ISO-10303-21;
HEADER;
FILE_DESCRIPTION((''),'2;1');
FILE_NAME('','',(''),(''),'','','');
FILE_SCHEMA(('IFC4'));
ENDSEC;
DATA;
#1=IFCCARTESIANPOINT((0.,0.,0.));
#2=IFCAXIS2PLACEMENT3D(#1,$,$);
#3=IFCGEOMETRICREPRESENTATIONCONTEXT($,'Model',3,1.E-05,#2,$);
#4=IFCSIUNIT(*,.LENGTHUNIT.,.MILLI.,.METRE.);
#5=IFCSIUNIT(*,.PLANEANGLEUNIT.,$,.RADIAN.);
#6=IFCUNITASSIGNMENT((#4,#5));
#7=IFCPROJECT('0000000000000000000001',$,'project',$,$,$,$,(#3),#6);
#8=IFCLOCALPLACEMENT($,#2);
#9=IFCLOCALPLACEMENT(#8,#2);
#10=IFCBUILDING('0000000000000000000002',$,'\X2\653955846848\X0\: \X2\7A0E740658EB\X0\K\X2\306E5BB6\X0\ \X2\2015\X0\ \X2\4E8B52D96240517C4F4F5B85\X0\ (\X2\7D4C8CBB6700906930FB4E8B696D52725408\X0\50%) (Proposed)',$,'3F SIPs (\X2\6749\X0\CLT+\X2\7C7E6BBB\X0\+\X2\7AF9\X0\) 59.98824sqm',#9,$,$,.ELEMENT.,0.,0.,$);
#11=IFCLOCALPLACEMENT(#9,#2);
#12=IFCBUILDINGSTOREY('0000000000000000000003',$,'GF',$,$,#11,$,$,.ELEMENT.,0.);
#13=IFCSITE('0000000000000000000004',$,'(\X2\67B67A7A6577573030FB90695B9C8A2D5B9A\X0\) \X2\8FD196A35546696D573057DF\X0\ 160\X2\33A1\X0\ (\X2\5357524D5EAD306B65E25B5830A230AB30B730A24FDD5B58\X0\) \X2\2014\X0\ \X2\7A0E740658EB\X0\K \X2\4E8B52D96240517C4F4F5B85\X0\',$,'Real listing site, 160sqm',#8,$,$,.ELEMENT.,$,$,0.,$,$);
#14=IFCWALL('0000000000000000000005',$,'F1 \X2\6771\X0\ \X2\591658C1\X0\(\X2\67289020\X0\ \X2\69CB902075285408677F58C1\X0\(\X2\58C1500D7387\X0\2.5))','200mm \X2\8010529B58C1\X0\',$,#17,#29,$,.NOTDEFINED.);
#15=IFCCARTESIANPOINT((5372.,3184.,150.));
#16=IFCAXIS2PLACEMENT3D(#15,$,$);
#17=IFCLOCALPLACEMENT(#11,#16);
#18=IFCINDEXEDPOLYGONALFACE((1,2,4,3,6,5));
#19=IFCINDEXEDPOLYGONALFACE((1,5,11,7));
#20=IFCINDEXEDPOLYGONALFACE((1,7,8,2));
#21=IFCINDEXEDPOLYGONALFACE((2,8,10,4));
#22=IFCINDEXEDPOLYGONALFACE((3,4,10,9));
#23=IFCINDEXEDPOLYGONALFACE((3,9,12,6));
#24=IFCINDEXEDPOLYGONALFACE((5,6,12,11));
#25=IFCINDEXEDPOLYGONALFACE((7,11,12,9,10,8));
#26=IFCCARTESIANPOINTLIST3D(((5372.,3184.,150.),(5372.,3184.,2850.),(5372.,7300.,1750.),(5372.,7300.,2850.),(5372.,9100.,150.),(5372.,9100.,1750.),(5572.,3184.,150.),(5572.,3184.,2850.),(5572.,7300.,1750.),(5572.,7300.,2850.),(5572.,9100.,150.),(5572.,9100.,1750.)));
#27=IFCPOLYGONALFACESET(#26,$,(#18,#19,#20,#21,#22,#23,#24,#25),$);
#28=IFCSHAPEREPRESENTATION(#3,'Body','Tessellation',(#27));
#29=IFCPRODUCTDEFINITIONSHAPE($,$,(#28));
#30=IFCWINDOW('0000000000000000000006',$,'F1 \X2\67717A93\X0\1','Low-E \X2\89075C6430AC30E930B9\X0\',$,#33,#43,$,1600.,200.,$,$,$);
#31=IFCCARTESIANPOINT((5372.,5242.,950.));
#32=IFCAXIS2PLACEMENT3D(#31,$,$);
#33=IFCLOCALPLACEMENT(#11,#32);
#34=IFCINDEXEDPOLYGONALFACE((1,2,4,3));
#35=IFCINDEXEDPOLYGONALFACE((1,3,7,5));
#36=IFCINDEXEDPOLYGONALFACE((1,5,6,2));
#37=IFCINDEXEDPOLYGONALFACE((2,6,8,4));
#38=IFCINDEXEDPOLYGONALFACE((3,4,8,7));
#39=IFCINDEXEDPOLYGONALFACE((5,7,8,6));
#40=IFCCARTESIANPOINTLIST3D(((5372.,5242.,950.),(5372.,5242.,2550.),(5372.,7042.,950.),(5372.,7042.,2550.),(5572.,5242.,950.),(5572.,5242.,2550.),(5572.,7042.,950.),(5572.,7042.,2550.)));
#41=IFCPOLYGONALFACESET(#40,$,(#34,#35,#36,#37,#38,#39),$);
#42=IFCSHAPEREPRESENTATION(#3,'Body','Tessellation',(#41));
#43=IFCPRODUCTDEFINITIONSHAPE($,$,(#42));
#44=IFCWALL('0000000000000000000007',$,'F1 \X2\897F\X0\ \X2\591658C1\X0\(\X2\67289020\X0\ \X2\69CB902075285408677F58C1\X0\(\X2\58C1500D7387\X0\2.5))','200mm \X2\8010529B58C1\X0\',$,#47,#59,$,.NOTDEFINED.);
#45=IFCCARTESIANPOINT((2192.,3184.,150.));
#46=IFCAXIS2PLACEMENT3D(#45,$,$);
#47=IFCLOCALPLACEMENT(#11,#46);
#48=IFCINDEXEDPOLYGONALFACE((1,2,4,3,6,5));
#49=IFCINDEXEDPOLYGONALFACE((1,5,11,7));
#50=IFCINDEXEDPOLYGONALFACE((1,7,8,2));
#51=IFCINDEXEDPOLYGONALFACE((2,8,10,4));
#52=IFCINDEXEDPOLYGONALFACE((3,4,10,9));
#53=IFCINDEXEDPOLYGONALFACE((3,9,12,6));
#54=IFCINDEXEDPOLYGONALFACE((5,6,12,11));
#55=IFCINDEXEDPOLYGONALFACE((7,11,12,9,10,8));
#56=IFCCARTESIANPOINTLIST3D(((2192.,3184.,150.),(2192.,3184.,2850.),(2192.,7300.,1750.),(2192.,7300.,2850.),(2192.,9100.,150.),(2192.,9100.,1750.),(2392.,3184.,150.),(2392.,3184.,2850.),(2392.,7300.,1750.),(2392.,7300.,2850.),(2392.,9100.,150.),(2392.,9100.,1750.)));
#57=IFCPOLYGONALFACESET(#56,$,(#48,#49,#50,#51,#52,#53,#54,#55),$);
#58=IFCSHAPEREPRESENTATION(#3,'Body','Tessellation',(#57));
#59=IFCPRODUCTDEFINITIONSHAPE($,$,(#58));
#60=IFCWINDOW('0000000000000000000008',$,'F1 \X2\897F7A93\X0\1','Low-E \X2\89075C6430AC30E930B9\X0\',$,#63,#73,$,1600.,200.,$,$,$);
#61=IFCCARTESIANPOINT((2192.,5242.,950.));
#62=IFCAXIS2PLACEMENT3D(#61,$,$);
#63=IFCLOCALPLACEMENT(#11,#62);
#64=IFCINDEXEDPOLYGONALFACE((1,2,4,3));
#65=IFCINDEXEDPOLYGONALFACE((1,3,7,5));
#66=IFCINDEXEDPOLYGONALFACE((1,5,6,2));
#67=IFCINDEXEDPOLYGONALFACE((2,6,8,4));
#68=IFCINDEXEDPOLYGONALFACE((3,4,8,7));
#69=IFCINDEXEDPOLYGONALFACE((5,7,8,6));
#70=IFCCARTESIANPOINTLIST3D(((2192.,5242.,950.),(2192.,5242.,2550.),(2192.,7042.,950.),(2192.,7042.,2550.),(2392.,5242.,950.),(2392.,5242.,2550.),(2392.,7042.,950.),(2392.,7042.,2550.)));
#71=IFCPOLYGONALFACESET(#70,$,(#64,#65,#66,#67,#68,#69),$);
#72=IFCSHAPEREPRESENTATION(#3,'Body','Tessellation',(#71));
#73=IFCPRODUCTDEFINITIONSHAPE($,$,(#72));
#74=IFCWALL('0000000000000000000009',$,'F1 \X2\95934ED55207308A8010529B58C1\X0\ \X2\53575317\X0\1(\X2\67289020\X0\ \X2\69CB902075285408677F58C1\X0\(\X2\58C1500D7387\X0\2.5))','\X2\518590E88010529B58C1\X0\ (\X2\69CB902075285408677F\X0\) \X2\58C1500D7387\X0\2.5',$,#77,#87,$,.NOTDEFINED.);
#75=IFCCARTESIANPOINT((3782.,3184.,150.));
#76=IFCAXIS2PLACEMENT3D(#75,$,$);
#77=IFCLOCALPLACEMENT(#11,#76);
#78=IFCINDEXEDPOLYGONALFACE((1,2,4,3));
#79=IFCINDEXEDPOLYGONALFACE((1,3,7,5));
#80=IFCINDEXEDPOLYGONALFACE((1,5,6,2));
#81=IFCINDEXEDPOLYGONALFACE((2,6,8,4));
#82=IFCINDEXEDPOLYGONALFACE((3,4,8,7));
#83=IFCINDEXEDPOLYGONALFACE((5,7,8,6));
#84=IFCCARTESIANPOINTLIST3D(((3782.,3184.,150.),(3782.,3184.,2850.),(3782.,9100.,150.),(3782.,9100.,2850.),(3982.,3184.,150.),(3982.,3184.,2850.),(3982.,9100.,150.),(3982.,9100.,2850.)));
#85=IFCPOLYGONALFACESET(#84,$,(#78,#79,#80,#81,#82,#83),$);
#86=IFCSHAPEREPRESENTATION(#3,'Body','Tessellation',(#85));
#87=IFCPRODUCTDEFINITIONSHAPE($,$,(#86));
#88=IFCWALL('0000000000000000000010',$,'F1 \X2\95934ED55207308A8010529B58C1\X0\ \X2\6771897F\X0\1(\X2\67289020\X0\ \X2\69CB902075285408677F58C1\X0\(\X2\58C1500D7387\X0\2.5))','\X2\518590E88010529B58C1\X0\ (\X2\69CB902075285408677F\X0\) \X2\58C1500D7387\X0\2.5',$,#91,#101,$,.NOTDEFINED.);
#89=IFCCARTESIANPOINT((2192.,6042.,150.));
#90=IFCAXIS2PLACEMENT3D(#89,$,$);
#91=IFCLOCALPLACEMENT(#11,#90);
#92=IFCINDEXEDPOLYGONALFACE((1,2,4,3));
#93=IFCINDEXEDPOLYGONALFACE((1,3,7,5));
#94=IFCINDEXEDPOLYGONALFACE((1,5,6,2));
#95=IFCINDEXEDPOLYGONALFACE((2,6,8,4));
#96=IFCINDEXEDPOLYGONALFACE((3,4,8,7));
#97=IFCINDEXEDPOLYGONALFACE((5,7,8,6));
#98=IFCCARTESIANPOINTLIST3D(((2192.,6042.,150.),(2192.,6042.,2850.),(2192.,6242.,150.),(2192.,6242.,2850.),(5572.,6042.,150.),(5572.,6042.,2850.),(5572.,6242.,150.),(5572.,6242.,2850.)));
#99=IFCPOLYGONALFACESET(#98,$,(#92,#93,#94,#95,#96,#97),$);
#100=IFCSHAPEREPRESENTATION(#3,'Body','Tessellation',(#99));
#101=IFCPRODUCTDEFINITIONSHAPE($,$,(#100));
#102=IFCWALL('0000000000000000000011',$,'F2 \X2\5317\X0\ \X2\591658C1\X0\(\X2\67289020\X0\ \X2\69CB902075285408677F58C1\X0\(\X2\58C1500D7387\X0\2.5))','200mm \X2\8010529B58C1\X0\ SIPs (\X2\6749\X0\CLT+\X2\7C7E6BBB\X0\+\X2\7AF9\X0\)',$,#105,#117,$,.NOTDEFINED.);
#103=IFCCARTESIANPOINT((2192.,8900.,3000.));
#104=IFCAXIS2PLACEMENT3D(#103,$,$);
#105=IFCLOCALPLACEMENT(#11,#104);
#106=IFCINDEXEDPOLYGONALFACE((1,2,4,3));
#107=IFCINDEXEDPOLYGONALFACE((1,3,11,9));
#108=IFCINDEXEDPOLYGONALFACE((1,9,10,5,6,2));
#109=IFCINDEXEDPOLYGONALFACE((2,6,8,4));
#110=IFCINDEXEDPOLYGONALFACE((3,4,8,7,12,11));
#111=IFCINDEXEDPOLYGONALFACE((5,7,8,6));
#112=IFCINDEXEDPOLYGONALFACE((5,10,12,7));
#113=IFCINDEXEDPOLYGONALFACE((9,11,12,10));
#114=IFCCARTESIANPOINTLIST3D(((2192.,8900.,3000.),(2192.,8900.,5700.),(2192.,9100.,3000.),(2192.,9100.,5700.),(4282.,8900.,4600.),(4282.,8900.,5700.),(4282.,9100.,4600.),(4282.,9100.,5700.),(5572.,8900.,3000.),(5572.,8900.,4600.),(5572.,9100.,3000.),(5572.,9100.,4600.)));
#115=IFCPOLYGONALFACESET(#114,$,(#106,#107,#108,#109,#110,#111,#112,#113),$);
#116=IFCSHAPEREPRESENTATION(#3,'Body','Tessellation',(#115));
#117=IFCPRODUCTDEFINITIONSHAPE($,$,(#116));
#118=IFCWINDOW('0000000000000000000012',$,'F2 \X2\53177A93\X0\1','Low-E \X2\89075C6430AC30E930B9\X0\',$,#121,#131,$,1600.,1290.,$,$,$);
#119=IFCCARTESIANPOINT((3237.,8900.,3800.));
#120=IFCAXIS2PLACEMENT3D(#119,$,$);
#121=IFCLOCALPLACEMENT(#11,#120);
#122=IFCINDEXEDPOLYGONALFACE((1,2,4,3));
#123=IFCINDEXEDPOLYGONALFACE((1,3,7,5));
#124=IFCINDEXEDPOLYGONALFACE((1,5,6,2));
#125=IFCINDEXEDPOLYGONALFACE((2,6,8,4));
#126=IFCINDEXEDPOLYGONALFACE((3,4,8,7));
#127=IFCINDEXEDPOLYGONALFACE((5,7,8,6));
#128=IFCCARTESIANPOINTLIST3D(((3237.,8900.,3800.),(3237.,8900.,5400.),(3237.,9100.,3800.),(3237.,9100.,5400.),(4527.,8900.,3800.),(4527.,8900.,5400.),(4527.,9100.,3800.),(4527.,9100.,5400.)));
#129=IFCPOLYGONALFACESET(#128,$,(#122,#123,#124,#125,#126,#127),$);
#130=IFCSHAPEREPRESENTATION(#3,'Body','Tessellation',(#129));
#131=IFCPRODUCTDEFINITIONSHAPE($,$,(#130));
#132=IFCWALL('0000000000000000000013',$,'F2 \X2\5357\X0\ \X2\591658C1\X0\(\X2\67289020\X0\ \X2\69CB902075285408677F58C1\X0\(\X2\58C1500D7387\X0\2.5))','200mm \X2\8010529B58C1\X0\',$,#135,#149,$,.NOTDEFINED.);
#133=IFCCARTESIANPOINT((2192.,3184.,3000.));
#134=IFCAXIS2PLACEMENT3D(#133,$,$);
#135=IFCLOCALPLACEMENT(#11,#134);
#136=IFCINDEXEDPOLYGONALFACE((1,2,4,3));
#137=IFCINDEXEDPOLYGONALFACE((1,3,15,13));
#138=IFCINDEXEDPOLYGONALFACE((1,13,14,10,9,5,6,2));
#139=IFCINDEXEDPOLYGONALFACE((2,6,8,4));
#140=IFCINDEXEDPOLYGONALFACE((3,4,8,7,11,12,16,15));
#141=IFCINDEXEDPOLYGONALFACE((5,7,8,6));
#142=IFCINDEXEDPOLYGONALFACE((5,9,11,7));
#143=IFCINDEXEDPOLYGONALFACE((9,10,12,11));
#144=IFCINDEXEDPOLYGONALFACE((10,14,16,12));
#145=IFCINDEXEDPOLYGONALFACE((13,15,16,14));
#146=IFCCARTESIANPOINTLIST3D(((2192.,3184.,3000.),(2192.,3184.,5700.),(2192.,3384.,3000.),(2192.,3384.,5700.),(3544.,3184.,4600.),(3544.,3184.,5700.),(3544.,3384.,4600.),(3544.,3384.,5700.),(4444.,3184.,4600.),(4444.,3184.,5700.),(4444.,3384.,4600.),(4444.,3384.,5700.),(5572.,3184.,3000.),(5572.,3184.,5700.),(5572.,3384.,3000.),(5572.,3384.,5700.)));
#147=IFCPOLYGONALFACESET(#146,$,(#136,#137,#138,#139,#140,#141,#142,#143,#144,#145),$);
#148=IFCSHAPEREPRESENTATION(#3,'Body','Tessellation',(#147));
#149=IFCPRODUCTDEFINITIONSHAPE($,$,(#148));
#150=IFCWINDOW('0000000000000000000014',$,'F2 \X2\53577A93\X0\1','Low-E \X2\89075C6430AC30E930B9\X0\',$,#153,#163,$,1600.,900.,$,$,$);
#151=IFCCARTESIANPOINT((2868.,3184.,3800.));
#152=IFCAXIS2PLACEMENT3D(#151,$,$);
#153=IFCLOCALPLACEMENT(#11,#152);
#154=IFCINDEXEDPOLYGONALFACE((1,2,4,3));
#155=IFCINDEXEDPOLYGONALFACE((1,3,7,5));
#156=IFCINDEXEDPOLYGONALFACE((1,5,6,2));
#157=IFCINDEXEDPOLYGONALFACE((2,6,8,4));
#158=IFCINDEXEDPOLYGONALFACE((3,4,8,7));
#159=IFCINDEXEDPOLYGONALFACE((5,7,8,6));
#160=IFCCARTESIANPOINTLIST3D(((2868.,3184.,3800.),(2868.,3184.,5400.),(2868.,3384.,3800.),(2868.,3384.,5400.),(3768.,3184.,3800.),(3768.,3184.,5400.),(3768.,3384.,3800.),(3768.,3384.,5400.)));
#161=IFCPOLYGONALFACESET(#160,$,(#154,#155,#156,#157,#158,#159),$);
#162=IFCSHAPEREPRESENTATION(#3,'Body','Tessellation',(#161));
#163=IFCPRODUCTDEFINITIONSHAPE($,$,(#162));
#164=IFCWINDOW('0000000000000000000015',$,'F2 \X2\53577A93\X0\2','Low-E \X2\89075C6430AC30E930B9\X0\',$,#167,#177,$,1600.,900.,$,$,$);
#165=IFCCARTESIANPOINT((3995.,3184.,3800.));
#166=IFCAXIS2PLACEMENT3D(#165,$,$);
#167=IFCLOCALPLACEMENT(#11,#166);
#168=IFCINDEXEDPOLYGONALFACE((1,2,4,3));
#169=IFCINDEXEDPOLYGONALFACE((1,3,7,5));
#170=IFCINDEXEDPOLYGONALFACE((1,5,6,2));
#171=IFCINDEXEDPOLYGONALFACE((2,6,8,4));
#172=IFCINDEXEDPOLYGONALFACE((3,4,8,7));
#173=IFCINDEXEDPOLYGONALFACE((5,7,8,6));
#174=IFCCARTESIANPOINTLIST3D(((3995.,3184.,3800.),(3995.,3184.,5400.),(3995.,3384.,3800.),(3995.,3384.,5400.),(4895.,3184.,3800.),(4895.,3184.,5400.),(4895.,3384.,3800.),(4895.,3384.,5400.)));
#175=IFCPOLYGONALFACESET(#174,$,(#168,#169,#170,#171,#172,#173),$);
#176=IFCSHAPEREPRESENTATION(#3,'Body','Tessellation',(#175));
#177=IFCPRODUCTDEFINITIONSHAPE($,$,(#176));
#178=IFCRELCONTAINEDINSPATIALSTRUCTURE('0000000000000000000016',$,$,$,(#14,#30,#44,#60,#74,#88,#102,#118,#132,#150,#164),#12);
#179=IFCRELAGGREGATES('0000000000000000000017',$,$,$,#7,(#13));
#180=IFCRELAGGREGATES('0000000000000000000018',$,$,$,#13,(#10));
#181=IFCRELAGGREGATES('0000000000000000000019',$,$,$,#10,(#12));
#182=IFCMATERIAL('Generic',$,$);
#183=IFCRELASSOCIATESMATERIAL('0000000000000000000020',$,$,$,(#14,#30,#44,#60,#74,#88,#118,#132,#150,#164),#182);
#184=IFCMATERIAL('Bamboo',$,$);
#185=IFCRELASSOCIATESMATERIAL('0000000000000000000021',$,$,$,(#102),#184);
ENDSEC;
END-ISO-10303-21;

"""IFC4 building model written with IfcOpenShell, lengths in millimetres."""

from ifc_helpers import new_model, si_unit, frame, frame_2d, origin, place, context, project, spatial, rectangle, extrude, material, element, fill, save


model = new_model("IFC4")

# Units and contexts
model_context = context("Model", 3, precision=1e-05, world=origin())
ifc_project = project(units=[si_unit("LENGTHUNIT", "METRE", prefix="MILLI"), si_unit("PLANEANGLEUNIT", "RADIAN")], contexts=[model_context])

# Site, building, storey
site_placement = place(None, origin())
site = spatial("IfcSite", under=ifc_project, at=site_placement, Name="(架空敷地・適宜設定) 近隣商業地域 160㎡ (南前庭に既存アカシア保存) — 税理士K 事務所兼住宅", ObjectType="Real listing site, 160sqm", CompositionType="ELEMENT", RefElevation=0.0)
building_placement = place(site_placement, origin())
building = spatial("IfcBuilding", under=site, at=building_placement, Name="改善案: 税理士Kの家 ― 事務所兼住宅 (経費最適・事業割合50%) (Proposed)", ObjectType="3F SIPs (杉CLT+籾殻+竹) 59.98824sqm", CompositionType="ELEMENT", ElevationOfRefHeight=0.0, ElevationOfTerrain=0.0)
storey_placement = place(building_placement, origin())
storey = spatial("IfcBuildingStorey", under=building, at=storey_placement, Name="GF", CompositionType="ELEMENT", Elevation=0.0)

# Shared definitions
ifc_material_1 = material(Name="Generic")

# Shared definitions
ifc_material_2 = material(Name="Bamboo")

# Walls, openings, windows
wall_1_placement = place(storey_placement, frame((5372.0, 3184.0, 150.0)))
wall_1 = element("IfcWall", 1, at=wall_1_placement, inside=storey, material=ifc_material_1, Name="F1 東 外壁(木造 構造用合板壁(壁倍率2.5))", Description="200mm 耐力壁", PredefinedType="NOTDEFINED", context=model_context, shape_type="SweptSolid", body=[
    extrude(rectangle(XDim=200.0, YDim=5916.0, at=frame_2d((100.0, 2958.0))), frame((5372.0, 3184.0, 150.0)), (0.0, 0.0, 1.0), 2700.0),
])
opening_1_placement = place(storey_placement, frame((5372.0, 5242.0, 950.0)))
opening_1 = element("IfcOpeningElement", 2, at=opening_1_placement, cuts=wall_1, PredefinedType="NOTDEFINED", context=model_context, shape_type="SweptSolid", body=[
    extrude(rectangle(XDim=200.0, YDim=1800.0, at=frame_2d((100.0, 900.0))), frame((5372.0, 5242.0, 950.0)), (0.0, 0.0, 1.0), 1600.0),
])
window_1_placement = place(storey_placement, frame((5372.0, 5242.0, 950.0)))
window_1 = element("IfcWindow", 3, at=window_1_placement, inside=storey, material=ifc_material_1, Name="F1 東窓1", Description="Low-E 複層ガラス", OverallHeight=1600.0, OverallWidth=200.0, context=model_context, shape_type="SweptSolid", body=[
    extrude(rectangle(XDim=200.0, YDim=1800.0, at=frame_2d((100.0, 900.0))), frame((5372.0, 5242.0, 950.0)), (0.0, 0.0, 1.0), 1600.0),
])
fill(opening_1, window_1)
wall_2_placement = place(storey_placement, frame((2192.0, 3184.0, 150.0)))
wall_2 = element("IfcWall", 4, at=wall_2_placement, inside=storey, material=ifc_material_1, Name="F1 西 外壁(木造 構造用合板壁(壁倍率2.5))", Description="200mm 耐力壁", PredefinedType="NOTDEFINED", context=model_context, shape_type="SweptSolid", body=[
    extrude(rectangle(XDim=200.0, YDim=5916.0, at=frame_2d((100.0, 2958.0))), frame((2192.0, 3184.0, 150.0)), (0.0, 0.0, 1.0), 2700.0),
])
opening_2_placement = place(storey_placement, frame((2192.0, 5242.0, 950.0)))
opening_2 = element("IfcOpeningElement", 5, at=opening_2_placement, cuts=wall_2, PredefinedType="NOTDEFINED", context=model_context, shape_type="SweptSolid", body=[
    extrude(rectangle(XDim=200.0, YDim=1800.0, at=frame_2d((100.0, 900.0))), frame((2192.0, 5242.0, 950.0)), (0.0, 0.0, 1.0), 1600.0),
])
window_2_placement = place(storey_placement, frame((2192.0, 5242.0, 950.0)))
window_2 = element("IfcWindow", 6, at=window_2_placement, inside=storey, material=ifc_material_1, Name="F1 西窓1", Description="Low-E 複層ガラス", OverallHeight=1600.0, OverallWidth=200.0, context=model_context, shape_type="SweptSolid", body=[
    extrude(rectangle(XDim=200.0, YDim=1800.0, at=frame_2d((100.0, 900.0))), frame((2192.0, 5242.0, 950.0)), (0.0, 0.0, 1.0), 1600.0),
])
fill(opening_2, window_2)

# Walls
wall_3_placement = place(storey_placement, frame((3782.0, 3184.0, 150.0)))
element("IfcWall", 7, at=wall_3_placement, inside=storey, material=ifc_material_1, Name="F1 間仕切り耐力壁 南北1(木造 構造用合板壁(壁倍率2.5))", Description="内部耐力壁 (構造用合板) 壁倍率2.5", PredefinedType="NOTDEFINED", context=model_context, shape_type="SweptSolid", body=[
    extrude(rectangle(XDim=200.0, YDim=5916.0, at=frame_2d((100.0, 2958.0))), frame((3782.0, 3184.0, 150.0)), (0.0, 0.0, 1.0), 2700.0),
])
wall_4_placement = place(storey_placement, frame((2192.0, 6042.0, 150.0)))
element("IfcWall", 8, at=wall_4_placement, inside=storey, material=ifc_material_1, Name="F1 間仕切り耐力壁 東西1(木造 構造用合板壁(壁倍率2.5))", Description="内部耐力壁 (構造用合板) 壁倍率2.5", PredefinedType="NOTDEFINED", context=model_context, shape_type="SweptSolid", body=[
    extrude(rectangle(XDim=3380.0, YDim=200.0, at=frame_2d((1690.0, 100.0))), frame((2192.0, 6042.0, 150.0)), (0.0, 0.0, 1.0), 2700.0),
])

# Wall, opening, window
wall_5_placement = place(storey_placement, frame((2192.0, 8900.0, 3000.0)))
wall_5 = element("IfcWall", 9, at=wall_5_placement, inside=storey, material=ifc_material_2, Name="F2 北 外壁(木造 構造用合板壁(壁倍率2.5))", Description="200mm 耐力壁 SIPs (杉CLT+籾殻+竹)", PredefinedType="NOTDEFINED", context=model_context, shape_type="SweptSolid", body=[
    extrude(rectangle(XDim=3380.0, YDim=200.0, at=frame_2d((1690.0, 100.0))), frame((2192.0, 8900.0, 3000.0)), (0.0, 0.0, 1.0), 2700.0),
])
opening_3_placement = place(storey_placement, frame((3237.0, 8900.0, 3800.0)))
opening_3 = element("IfcOpeningElement", 10, at=opening_3_placement, cuts=wall_5, PredefinedType="NOTDEFINED", context=model_context, shape_type="SweptSolid", body=[
    extrude(rectangle(XDim=1290.0, YDim=200.0, at=frame_2d((645.0, 100.0))), frame((3237.0, 8900.0, 3800.0)), (0.0, 0.0, 1.0), 1600.0),
])
window_3_placement = place(storey_placement, frame((3237.0, 8900.0, 3800.0)))
window_3 = element("IfcWindow", 11, at=window_3_placement, inside=storey, material=ifc_material_1, Name="F2 北窓1", Description="Low-E 複層ガラス", OverallHeight=1600.0, OverallWidth=1290.0, context=model_context, shape_type="SweptSolid", body=[
    extrude(rectangle(XDim=1290.0, YDim=200.0, at=frame_2d((645.0, 100.0))), frame((3237.0, 8900.0, 3800.0)), (0.0, 0.0, 1.0), 1600.0),
])
fill(opening_3, window_3)

# Wall, openings, windows
wall_6_placement = place(storey_placement, frame((2192.0, 3184.0, 3000.0)))
wall_6 = element("IfcWall", 12, at=wall_6_placement, inside=storey, material=ifc_material_1, Name="F2 南 外壁(木造 構造用合板壁(壁倍率2.5))", Description="200mm 耐力壁", PredefinedType="NOTDEFINED", context=model_context, shape_type="SweptSolid", body=[
    extrude(rectangle(XDim=3380.0, YDim=200.0, at=frame_2d((1690.0, 100.0))), frame((2192.0, 3184.0, 3000.0)), (0.0, 0.0, 1.0), 2700.0),
])
opening_4_placement = place(storey_placement, frame((2868.0, 3184.0, 3800.0)))
opening_4 = element("IfcOpeningElement", 13, at=opening_4_placement, cuts=wall_6, PredefinedType="NOTDEFINED", context=model_context, shape_type="SweptSolid", body=[
    extrude(rectangle(XDim=900.0, YDim=200.0, at=frame_2d((450.0, 100.0))), frame((2868.0, 3184.0, 3800.0)), (0.0, 0.0, 1.0), 1600.0),
])
opening_5_placement = place(storey_placement, frame((3995.0, 3184.0, 3800.0)))
opening_5 = element("IfcOpeningElement", 14, at=opening_5_placement, cuts=wall_6, PredefinedType="NOTDEFINED", context=model_context, shape_type="SweptSolid", body=[
    extrude(rectangle(XDim=900.0, YDim=200.0, at=frame_2d((450.0, 100.0))), frame((3995.0, 3184.0, 3800.0)), (0.0, 0.0, 1.0), 1600.0),
])
window_4_placement = place(storey_placement, frame((2868.0, 3184.0, 3800.0)))
window_4 = element("IfcWindow", 15, at=window_4_placement, inside=storey, material=ifc_material_1, Name="F2 南窓1", Description="Low-E 複層ガラス", OverallHeight=1600.0, OverallWidth=900.0, context=model_context, shape_type="SweptSolid", body=[
    extrude(rectangle(XDim=900.0, YDim=200.0, at=frame_2d((450.0, 100.0))), frame((2868.0, 3184.0, 3800.0)), (0.0, 0.0, 1.0), 1600.0),
])
fill(opening_4, window_4)
window_5_placement = place(storey_placement, frame((3995.0, 3184.0, 3800.0)))
window_5 = element("IfcWindow", 16, at=window_5_placement, inside=storey, material=ifc_material_1, Name="F2 南窓2", Description="Low-E 複層ガラス", OverallHeight=1600.0, OverallWidth=900.0, context=model_context, shape_type="SweptSolid", body=[
    extrude(rectangle(XDim=900.0, YDim=200.0, at=frame_2d((450.0, 100.0))), frame((3995.0, 3184.0, 3800.0)), (0.0, 0.0, 1.0), 1600.0),
])
fill(opening_5, window_5)

save(model, "model.ifc")
